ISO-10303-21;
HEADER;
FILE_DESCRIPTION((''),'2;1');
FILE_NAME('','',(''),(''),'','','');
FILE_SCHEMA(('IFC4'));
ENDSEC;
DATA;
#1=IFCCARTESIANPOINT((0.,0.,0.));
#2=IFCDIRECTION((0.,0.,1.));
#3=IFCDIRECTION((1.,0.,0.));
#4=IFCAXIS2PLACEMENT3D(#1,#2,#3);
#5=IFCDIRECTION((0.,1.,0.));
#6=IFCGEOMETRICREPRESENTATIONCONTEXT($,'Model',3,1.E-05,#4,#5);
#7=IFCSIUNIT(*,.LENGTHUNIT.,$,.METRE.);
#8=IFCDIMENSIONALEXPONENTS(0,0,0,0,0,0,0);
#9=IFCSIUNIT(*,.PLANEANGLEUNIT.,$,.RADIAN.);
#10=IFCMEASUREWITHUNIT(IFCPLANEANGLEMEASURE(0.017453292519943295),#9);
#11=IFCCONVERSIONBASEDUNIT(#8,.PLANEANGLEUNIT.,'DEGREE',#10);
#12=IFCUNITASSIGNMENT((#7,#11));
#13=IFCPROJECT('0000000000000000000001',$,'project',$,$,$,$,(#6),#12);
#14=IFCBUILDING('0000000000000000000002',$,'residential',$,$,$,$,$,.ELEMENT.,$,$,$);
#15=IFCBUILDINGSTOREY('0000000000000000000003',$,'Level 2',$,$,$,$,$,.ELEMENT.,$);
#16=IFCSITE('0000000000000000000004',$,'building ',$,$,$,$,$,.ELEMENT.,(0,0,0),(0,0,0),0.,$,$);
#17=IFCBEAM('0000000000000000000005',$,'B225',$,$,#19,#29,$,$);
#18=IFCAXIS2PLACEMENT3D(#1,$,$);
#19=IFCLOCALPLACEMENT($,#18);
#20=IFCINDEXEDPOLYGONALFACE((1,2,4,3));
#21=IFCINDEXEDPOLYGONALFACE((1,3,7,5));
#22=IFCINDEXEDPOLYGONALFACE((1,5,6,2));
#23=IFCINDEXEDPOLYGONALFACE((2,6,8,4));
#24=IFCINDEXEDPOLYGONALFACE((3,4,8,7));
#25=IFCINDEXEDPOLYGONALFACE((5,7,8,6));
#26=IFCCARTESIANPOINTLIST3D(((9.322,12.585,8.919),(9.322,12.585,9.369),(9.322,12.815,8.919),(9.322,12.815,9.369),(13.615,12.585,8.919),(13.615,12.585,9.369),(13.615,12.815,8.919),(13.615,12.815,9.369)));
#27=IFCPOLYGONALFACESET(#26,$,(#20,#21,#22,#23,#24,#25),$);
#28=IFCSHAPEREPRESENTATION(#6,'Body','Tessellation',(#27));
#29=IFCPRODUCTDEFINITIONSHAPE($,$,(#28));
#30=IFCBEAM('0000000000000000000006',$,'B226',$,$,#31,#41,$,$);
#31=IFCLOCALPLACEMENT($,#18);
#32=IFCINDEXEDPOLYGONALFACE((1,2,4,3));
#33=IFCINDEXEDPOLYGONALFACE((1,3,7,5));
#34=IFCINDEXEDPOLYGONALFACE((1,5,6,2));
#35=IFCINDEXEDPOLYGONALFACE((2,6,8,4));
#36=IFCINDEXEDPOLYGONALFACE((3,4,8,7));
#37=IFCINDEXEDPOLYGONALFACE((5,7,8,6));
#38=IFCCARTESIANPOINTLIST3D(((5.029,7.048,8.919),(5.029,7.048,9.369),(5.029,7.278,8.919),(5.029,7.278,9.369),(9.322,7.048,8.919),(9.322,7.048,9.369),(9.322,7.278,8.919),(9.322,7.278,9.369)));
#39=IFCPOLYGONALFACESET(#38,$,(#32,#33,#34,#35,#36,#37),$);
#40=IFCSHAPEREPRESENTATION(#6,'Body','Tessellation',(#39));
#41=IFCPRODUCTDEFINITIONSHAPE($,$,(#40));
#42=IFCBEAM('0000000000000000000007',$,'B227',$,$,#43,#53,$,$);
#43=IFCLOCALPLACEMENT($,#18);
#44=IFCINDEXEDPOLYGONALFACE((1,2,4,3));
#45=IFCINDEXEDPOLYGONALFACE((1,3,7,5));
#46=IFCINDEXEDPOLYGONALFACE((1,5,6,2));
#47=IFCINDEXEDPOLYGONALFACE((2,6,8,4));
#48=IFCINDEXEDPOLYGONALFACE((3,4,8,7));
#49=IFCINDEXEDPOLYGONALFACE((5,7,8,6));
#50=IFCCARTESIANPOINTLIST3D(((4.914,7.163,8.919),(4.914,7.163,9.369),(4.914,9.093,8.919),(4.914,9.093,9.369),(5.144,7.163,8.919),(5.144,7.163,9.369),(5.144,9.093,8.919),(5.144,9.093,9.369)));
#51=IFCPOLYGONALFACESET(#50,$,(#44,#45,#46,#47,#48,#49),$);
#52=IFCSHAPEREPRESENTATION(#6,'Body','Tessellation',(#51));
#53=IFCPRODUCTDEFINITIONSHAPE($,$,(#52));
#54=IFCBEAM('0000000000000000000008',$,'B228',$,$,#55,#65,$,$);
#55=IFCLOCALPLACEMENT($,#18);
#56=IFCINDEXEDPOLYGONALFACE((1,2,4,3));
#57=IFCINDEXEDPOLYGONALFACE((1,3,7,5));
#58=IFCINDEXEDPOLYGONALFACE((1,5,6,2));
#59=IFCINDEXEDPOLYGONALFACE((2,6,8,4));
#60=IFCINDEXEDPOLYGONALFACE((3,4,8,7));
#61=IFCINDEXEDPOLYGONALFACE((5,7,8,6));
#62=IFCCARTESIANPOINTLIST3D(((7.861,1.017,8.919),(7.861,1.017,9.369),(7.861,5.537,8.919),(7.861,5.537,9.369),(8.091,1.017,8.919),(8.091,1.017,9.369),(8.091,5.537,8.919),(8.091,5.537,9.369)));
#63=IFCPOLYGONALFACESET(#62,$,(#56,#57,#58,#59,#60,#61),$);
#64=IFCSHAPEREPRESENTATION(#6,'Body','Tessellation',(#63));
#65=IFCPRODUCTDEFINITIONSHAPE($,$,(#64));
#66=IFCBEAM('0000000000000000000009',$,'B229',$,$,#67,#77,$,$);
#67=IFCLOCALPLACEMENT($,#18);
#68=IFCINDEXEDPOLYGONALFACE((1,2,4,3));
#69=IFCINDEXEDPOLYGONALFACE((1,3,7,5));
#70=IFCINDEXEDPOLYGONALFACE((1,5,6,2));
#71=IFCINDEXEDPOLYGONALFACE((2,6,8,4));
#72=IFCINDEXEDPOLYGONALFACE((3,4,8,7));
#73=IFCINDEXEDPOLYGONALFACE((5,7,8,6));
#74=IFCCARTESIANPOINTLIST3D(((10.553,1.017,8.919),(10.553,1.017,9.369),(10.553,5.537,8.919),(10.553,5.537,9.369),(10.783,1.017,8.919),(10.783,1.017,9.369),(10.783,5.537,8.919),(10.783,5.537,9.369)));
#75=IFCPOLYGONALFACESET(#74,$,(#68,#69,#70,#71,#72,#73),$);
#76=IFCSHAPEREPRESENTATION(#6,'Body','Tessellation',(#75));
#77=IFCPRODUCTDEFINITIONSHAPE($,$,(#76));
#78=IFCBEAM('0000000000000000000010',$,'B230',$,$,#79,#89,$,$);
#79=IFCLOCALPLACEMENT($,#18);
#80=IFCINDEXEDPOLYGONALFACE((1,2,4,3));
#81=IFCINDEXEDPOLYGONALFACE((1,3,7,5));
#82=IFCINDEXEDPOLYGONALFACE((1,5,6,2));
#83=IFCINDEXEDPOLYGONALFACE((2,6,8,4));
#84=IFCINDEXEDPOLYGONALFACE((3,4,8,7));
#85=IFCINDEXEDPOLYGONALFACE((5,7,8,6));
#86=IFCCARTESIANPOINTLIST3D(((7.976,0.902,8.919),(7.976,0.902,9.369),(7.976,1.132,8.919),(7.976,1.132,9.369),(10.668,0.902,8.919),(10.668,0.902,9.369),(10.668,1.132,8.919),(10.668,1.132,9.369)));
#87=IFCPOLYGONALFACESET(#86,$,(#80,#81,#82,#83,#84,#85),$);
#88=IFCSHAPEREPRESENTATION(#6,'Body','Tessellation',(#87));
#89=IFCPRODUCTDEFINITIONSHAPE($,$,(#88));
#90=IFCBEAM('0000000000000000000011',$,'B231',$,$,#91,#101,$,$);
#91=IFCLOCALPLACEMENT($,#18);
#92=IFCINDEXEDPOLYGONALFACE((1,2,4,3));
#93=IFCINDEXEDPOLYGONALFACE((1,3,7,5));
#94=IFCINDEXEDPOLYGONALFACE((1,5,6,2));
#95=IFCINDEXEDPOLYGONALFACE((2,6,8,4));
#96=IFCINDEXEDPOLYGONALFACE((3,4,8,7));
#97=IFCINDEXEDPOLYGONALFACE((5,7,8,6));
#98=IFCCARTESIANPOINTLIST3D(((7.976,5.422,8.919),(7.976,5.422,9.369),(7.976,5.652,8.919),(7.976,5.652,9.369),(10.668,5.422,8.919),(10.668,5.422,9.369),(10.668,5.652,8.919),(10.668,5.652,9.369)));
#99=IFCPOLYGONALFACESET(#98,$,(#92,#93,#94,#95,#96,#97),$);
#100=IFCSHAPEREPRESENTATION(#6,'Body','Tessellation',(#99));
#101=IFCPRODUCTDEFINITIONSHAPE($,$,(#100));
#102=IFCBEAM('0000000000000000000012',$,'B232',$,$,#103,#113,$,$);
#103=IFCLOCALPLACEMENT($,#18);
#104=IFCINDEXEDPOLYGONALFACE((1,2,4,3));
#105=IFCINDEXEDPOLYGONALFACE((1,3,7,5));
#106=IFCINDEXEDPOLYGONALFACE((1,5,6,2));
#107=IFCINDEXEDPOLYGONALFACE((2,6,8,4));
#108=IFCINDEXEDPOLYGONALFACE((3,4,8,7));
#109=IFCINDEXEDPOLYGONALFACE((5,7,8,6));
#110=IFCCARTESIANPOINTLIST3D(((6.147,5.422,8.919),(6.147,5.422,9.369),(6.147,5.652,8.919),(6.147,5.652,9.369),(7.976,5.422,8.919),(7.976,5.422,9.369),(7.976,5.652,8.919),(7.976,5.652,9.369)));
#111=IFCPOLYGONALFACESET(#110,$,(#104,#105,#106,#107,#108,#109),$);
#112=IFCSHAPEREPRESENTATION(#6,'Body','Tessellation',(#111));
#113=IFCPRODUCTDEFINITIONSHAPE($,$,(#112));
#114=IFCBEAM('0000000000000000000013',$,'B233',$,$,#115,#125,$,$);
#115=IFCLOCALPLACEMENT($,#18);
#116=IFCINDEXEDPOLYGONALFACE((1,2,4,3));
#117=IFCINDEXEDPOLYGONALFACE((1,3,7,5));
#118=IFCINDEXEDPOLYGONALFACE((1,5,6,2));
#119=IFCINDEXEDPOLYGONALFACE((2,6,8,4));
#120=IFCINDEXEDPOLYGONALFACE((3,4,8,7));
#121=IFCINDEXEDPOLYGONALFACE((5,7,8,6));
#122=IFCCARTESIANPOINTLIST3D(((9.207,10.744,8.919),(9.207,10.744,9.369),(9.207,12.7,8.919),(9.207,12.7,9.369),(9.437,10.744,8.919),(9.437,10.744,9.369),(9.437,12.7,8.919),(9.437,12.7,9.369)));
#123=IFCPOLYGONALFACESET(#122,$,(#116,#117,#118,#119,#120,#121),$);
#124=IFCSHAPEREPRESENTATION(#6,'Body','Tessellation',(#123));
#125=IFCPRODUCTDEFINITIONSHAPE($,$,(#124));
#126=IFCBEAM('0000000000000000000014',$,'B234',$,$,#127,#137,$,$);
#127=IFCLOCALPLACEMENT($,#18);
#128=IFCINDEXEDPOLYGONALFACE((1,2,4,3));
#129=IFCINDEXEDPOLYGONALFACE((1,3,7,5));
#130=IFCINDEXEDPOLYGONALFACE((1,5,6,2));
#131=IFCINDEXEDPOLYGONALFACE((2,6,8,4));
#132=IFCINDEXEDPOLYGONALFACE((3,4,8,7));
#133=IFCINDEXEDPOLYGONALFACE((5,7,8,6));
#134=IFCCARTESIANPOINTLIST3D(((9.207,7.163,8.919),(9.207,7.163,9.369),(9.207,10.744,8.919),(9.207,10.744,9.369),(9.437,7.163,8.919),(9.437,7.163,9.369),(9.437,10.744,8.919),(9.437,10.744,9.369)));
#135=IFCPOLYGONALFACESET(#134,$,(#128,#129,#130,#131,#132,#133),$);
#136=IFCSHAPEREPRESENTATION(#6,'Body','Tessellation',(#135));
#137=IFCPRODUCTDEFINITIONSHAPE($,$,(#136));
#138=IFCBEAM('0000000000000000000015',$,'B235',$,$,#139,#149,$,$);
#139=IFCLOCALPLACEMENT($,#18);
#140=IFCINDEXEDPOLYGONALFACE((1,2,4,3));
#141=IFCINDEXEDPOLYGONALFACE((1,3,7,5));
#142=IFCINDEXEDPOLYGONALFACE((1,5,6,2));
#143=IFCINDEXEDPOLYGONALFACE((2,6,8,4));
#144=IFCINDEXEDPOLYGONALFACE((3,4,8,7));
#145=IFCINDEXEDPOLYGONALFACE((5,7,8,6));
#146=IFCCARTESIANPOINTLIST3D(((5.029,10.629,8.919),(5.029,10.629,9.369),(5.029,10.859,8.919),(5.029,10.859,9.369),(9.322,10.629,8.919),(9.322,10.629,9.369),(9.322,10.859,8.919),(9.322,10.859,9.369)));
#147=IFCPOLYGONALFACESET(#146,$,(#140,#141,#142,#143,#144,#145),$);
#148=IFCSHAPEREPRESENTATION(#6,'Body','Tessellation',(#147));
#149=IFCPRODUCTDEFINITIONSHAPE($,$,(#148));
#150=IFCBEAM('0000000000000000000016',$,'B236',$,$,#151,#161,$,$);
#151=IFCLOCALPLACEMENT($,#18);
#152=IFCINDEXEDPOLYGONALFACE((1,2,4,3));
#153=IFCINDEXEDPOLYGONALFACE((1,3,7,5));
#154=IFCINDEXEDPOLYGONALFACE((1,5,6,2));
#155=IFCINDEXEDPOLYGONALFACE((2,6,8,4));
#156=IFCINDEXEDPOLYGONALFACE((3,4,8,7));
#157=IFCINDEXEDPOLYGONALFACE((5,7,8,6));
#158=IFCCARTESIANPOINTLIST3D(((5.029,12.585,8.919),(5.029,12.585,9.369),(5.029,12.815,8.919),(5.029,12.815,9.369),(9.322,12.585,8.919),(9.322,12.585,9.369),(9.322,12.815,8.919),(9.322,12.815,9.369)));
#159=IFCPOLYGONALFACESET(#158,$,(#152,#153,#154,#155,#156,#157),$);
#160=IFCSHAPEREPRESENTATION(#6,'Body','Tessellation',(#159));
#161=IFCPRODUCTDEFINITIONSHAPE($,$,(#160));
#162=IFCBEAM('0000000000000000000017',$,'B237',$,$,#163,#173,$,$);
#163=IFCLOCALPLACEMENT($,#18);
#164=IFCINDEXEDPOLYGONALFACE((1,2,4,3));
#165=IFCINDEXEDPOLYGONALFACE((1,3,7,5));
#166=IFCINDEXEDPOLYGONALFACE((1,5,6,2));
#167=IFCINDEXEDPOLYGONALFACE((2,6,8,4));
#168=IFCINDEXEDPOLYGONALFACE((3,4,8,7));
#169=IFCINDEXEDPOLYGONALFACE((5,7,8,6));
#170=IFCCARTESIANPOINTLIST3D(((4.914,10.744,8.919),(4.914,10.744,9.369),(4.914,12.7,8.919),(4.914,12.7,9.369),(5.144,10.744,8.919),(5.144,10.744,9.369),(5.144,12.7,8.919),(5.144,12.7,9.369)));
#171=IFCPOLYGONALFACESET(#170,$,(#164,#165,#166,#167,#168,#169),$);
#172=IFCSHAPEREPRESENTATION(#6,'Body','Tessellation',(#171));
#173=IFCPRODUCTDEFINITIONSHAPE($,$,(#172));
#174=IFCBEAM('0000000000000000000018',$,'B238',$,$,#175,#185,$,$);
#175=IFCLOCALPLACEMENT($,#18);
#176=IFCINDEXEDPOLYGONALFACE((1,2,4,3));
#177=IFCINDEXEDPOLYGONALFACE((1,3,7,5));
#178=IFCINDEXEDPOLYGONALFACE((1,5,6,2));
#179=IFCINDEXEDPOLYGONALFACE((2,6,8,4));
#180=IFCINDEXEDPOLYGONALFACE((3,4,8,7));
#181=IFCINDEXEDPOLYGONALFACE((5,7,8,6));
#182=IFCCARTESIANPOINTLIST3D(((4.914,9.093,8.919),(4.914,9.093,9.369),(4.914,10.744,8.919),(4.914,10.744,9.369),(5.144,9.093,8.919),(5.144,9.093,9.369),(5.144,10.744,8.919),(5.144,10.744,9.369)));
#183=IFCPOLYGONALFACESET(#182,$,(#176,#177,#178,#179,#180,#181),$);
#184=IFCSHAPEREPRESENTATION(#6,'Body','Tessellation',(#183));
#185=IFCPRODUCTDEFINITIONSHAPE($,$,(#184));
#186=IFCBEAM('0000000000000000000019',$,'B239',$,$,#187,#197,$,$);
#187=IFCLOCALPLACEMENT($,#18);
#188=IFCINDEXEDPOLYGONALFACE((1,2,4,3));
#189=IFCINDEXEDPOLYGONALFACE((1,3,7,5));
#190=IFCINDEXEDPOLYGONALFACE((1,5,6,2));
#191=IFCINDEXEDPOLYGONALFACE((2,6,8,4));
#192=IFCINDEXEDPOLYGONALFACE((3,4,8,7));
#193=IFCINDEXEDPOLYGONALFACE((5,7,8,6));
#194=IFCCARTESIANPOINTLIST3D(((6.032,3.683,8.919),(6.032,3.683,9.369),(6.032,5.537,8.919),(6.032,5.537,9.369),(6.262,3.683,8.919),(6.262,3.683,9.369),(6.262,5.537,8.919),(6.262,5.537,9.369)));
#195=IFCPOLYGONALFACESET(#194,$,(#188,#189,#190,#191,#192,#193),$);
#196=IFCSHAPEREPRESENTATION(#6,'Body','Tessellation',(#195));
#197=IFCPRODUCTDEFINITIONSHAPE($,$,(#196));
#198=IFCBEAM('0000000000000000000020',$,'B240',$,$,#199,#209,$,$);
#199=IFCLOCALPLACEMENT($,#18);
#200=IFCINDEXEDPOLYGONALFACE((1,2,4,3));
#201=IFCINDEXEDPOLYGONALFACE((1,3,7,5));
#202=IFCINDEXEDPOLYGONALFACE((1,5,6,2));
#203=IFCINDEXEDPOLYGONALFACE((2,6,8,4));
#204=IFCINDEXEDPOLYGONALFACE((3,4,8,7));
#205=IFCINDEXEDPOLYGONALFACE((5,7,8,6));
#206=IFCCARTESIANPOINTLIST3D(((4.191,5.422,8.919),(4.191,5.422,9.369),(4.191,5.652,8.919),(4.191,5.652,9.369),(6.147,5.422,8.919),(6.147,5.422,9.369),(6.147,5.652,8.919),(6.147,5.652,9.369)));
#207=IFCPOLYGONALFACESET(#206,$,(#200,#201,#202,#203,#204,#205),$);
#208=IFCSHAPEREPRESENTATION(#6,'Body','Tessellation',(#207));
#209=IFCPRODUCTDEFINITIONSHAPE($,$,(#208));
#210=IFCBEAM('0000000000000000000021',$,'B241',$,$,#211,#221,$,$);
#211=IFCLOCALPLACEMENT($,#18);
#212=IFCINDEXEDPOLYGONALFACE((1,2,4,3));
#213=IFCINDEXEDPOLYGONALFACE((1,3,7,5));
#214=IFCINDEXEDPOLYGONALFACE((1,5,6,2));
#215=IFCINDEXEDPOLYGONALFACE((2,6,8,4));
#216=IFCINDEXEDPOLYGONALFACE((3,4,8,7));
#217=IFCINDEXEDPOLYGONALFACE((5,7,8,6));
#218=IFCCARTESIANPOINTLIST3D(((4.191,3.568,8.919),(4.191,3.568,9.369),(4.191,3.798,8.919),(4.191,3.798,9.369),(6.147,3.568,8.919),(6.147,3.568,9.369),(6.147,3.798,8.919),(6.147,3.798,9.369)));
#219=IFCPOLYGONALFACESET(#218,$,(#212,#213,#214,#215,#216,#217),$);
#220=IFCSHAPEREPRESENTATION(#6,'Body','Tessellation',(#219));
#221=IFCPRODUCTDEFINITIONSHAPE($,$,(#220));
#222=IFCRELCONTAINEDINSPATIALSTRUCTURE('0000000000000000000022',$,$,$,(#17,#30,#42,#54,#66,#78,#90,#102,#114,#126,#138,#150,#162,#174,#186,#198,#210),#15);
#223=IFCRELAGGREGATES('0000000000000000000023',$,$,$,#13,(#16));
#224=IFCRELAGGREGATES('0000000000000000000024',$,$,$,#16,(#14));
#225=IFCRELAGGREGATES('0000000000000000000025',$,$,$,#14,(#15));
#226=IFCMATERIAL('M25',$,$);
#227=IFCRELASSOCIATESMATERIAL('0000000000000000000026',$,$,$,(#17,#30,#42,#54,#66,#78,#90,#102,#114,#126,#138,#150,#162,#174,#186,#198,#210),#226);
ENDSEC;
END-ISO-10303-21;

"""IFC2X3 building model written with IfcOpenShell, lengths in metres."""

from ifc_helpers import new_model, entity, si_unit, converted_unit, direction, frame, frame_2d, origin_with_axes, place, context, project, spatial, rectangle, extrude, material, element, save


model = new_model("IFC2X3")

# Units and contexts
model_context = context("Model", 3, precision=1e-05, world=origin_with_axes(), true_north=direction((0.0, 1.0, 0.0)))
ifc_project = project(units=[si_unit("LENGTHUNIT", "METRE"), converted_unit("PLANEANGLEUNIT", "DEGREE", entity("IfcPlaneAngleMeasure", 0.017453292519943295), si_unit("PLANEANGLEUNIT", "RADIAN"), dimensions=[0, 0, 0, 0, 0, 0, 0])], contexts=[model_context])

# Site, building, storey
site = spatial("IfcSite", under=ifc_project, Name="building ", CompositionType="ELEMENT", RefLatitude=(0, 0, 0), RefLongitude=(0, 0, 0), RefElevation=0.0)
building = spatial("IfcBuilding", under=site, Name="residential", CompositionType="ELEMENT")
storey = spatial("IfcBuildingStorey", under=building, Name="Level 2", CompositionType="ELEMENT")

# Beams
ifc_material = material(Name="M25")
placement = place(None, origin_with_axes())
element("IfcBeam", 1, at=placement, inside=storey, material=ifc_material, Name="B225", context=model_context, shape_type="SweptSolid", body=[
    extrude(rectangle(XDim=0.23, YDim=0.45, at=frame_2d((0.0, 0.0), x_axis=(0.0, 1.0, 0.0))), frame((9.322, 12.7, 9.144), z_axis=(1.0, 0.0, 0.0), x_axis=(0.0, 0.0, -1.0)), (0.0, 0.0, 1.0), 4.293),
])
element("IfcBeam", 2, at=placement, inside=storey, material=ifc_material, Name="B226", context=model_context, shape_type="SweptSolid", body=[
    extrude(rectangle(XDim=0.23, YDim=0.45, at=frame_2d((0.0, 0.0), x_axis=(0.0, 1.0, 0.0))), frame((5.029, 7.163, 9.144), z_axis=(1.0, 0.0, 0.0), x_axis=(0.0, 0.0, -1.0)), (0.0, 0.0, 1.0), 4.293),
])
element("IfcBeam", 3, at=placement, inside=storey, material=ifc_material, Name="B227", context=model_context, shape_type="SweptSolid", body=[
    extrude(rectangle(XDim=0.23, YDim=0.45, at=frame_2d((0.0, 0.0), x_axis=(0.0, 1.0, 0.0))), frame((5.029, 9.093, 9.144), z_axis=(0.0, -1.0, 0.0), x_axis=(0.0, 0.0, -1.0)), (0.0, 0.0, 1.0), 1.93),
])
element("IfcBeam", 4, at=placement, inside=storey, material=ifc_material, Name="B228", context=model_context, shape_type="SweptSolid", body=[
    extrude(rectangle(XDim=0.23, YDim=0.45, at=frame_2d((0.0, 0.0), x_axis=(0.0, 1.0, 0.0))), frame((7.976, 1.017, 9.144), z_axis=(0.0, 1.0, 0.0), x_axis=(0.0, 0.0, -1.0)), (0.0, 0.0, 1.0), 4.52),
])
element("IfcBeam", 5, at=placement, inside=storey, material=ifc_material, Name="B229", context=model_context, shape_type="SweptSolid", body=[
    extrude(rectangle(XDim=0.23, YDim=0.45, at=frame_2d((0.0, 0.0), x_axis=(0.0, 1.0, 0.0))), frame((10.668, 1.017, 9.144), z_axis=(0.0, 1.0, 0.0), x_axis=(0.0, 0.0, -1.0)), (0.0, 0.0, 1.0), 4.52),
])
element("IfcBeam", 6, at=placement, inside=storey, material=ifc_material, Name="B230", context=model_context, shape_type="SweptSolid", body=[
    extrude(rectangle(XDim=0.23, YDim=0.45, at=frame_2d((0.0, 0.0), x_axis=(0.0, 1.0, 0.0))), frame((7.976, 1.017, 9.144), z_axis=(1.0, 0.0, 0.0), x_axis=(0.0, 0.0, -1.0)), (0.0, 0.0, 1.0), 2.692),
])
element("IfcBeam", 7, at=placement, inside=storey, material=ifc_material, Name="B231", context=model_context, shape_type="SweptSolid", body=[
    extrude(rectangle(XDim=0.23, YDim=0.45, at=frame_2d((0.0, 0.0), x_axis=(0.0, 1.0, 0.0))), frame((7.976, 5.537, 9.144), z_axis=(1.0, 0.0, 0.0), x_axis=(0.0, 0.0, -1.0)), (0.0, 0.0, 1.0), 2.692),
])
element("IfcBeam", 8, at=placement, inside=storey, material=ifc_material, Name="B232", context=model_context, shape_type="SweptSolid", body=[
    extrude(rectangle(XDim=0.23, YDim=0.45, at=frame_2d((0.0, 0.0), x_axis=(0.0, 1.0, 0.0))), frame((6.147, 5.537, 9.144), z_axis=(1.0, 0.0, 0.0), x_axis=(0.0, 0.0, -1.0)), (0.0, 0.0, 1.0), 1.829),
])
element("IfcBeam", 9, at=placement, inside=storey, material=ifc_material, Name="B233", context=model_context, shape_type="SweptSolid", body=[
    extrude(rectangle(XDim=0.23, YDim=0.45, at=frame_2d((0.0, 0.0), x_axis=(0.0, 1.0, 0.0))), frame((9.322, 10.744, 9.144), z_axis=(0.0, 1.0, 0.0), x_axis=(0.0, 0.0, -1.0)), (0.0, 0.0, 1.0), 1.956),
])
element("IfcBeam", 10, at=placement, inside=storey, material=ifc_material, Name="B234", context=model_context, shape_type="SweptSolid", body=[
    extrude(rectangle(XDim=0.23, YDim=0.45, at=frame_2d((0.0, 0.0), x_axis=(0.0, 1.0, 0.0))), frame((9.322, 7.163, 9.144), z_axis=(0.0, 1.0, 0.0), x_axis=(0.0, 0.0, -1.0)), (0.0, 0.0, 1.0), 3.581),
])
element("IfcBeam", 11, at=placement, inside=storey, material=ifc_material, Name="B235", context=model_context, shape_type="SweptSolid", body=[
    extrude(rectangle(XDim=0.23, YDim=0.45, at=frame_2d((0.0, 0.0), x_axis=(0.0, 1.0, 0.0))), frame((5.029, 10.744, 9.144), z_axis=(1.0, 0.0, 0.0), x_axis=(0.0, 0.0, -1.0)), (0.0, 0.0, 1.0), 4.293),
])
element("IfcBeam", 12, at=placement, inside=storey, material=ifc_material, Name="B236", context=model_context, shape_type="SweptSolid", body=[
    extrude(rectangle(XDim=0.23, YDim=0.45, at=frame_2d((0.0, 0.0), x_axis=(0.0, 1.0, 0.0))), frame((5.029, 12.7, 9.144), z_axis=(1.0, 0.0, 0.0), x_axis=(0.0, 0.0, -1.0)), (0.0, 0.0, 1.0), 4.293),
])
element("IfcBeam", 13, at=placement, inside=storey, material=ifc_material, Name="B237", context=model_context, shape_type="SweptSolid", body=[
    extrude(rectangle(XDim=0.23, YDim=0.45, at=frame_2d((0.0, 0.0), x_axis=(0.0, 1.0, 0.0))), frame((5.029, 10.744, 9.144), z_axis=(0.0, 1.0, 0.0), x_axis=(0.0, 0.0, -1.0)), (0.0, 0.0, 1.0), 1.956),
])
element("IfcBeam", 14, at=placement, inside=storey, material=ifc_material, Name="B238", context=model_context, shape_type="SweptSolid", body=[
    extrude(rectangle(XDim=0.23, YDim=0.45, at=frame_2d((0.0, 0.0), x_axis=(0.0, 1.0, 0.0))), frame((5.029, 9.093, 9.144), z_axis=(0.0, 1.0, 0.0), x_axis=(0.0, 0.0, -1.0)), (0.0, 0.0, 1.0), 1.651),
])
element("IfcBeam", 15, at=placement, inside=storey, material=ifc_material, Name="B239", context=model_context, shape_type="SweptSolid", body=[
    extrude(rectangle(XDim=0.23, YDim=0.45, at=frame_2d((0.0, 0.0), x_axis=(0.0, 1.0, 0.0))), frame((6.147, 3.683, 9.144), z_axis=(0.0, 1.0, 0.0), x_axis=(0.0, 0.0, -1.0)), (0.0, 0.0, 1.0), 1.854),
])
element("IfcBeam", 16, at=placement, inside=storey, material=ifc_material, Name="B240", context=model_context, shape_type="SweptSolid", body=[
    extrude(rectangle(XDim=0.23, YDim=0.45, at=frame_2d((0.0, 0.0), x_axis=(0.0, 1.0, 0.0))), frame((4.191, 5.537, 9.144), z_axis=(1.0, 0.0, 0.0), x_axis=(0.0, 0.0, -1.0)), (0.0, 0.0, 1.0), 1.956),
])
element("IfcBeam", 17, at=placement, inside=storey, material=ifc_material, Name="B241", context=model_context, shape_type="SweptSolid", body=[
    extrude(rectangle(XDim=0.23, YDim=0.45, at=frame_2d((0.0, 0.0), x_axis=(0.0, 1.0, 0.0))), frame((4.191, 3.683, 9.144), z_axis=(1.0, 0.0, 0.0), x_axis=(0.0, 0.0, -1.0)), (0.0, 0.0, 1.0), 1.956),
])

save(model, "model.ifc")
